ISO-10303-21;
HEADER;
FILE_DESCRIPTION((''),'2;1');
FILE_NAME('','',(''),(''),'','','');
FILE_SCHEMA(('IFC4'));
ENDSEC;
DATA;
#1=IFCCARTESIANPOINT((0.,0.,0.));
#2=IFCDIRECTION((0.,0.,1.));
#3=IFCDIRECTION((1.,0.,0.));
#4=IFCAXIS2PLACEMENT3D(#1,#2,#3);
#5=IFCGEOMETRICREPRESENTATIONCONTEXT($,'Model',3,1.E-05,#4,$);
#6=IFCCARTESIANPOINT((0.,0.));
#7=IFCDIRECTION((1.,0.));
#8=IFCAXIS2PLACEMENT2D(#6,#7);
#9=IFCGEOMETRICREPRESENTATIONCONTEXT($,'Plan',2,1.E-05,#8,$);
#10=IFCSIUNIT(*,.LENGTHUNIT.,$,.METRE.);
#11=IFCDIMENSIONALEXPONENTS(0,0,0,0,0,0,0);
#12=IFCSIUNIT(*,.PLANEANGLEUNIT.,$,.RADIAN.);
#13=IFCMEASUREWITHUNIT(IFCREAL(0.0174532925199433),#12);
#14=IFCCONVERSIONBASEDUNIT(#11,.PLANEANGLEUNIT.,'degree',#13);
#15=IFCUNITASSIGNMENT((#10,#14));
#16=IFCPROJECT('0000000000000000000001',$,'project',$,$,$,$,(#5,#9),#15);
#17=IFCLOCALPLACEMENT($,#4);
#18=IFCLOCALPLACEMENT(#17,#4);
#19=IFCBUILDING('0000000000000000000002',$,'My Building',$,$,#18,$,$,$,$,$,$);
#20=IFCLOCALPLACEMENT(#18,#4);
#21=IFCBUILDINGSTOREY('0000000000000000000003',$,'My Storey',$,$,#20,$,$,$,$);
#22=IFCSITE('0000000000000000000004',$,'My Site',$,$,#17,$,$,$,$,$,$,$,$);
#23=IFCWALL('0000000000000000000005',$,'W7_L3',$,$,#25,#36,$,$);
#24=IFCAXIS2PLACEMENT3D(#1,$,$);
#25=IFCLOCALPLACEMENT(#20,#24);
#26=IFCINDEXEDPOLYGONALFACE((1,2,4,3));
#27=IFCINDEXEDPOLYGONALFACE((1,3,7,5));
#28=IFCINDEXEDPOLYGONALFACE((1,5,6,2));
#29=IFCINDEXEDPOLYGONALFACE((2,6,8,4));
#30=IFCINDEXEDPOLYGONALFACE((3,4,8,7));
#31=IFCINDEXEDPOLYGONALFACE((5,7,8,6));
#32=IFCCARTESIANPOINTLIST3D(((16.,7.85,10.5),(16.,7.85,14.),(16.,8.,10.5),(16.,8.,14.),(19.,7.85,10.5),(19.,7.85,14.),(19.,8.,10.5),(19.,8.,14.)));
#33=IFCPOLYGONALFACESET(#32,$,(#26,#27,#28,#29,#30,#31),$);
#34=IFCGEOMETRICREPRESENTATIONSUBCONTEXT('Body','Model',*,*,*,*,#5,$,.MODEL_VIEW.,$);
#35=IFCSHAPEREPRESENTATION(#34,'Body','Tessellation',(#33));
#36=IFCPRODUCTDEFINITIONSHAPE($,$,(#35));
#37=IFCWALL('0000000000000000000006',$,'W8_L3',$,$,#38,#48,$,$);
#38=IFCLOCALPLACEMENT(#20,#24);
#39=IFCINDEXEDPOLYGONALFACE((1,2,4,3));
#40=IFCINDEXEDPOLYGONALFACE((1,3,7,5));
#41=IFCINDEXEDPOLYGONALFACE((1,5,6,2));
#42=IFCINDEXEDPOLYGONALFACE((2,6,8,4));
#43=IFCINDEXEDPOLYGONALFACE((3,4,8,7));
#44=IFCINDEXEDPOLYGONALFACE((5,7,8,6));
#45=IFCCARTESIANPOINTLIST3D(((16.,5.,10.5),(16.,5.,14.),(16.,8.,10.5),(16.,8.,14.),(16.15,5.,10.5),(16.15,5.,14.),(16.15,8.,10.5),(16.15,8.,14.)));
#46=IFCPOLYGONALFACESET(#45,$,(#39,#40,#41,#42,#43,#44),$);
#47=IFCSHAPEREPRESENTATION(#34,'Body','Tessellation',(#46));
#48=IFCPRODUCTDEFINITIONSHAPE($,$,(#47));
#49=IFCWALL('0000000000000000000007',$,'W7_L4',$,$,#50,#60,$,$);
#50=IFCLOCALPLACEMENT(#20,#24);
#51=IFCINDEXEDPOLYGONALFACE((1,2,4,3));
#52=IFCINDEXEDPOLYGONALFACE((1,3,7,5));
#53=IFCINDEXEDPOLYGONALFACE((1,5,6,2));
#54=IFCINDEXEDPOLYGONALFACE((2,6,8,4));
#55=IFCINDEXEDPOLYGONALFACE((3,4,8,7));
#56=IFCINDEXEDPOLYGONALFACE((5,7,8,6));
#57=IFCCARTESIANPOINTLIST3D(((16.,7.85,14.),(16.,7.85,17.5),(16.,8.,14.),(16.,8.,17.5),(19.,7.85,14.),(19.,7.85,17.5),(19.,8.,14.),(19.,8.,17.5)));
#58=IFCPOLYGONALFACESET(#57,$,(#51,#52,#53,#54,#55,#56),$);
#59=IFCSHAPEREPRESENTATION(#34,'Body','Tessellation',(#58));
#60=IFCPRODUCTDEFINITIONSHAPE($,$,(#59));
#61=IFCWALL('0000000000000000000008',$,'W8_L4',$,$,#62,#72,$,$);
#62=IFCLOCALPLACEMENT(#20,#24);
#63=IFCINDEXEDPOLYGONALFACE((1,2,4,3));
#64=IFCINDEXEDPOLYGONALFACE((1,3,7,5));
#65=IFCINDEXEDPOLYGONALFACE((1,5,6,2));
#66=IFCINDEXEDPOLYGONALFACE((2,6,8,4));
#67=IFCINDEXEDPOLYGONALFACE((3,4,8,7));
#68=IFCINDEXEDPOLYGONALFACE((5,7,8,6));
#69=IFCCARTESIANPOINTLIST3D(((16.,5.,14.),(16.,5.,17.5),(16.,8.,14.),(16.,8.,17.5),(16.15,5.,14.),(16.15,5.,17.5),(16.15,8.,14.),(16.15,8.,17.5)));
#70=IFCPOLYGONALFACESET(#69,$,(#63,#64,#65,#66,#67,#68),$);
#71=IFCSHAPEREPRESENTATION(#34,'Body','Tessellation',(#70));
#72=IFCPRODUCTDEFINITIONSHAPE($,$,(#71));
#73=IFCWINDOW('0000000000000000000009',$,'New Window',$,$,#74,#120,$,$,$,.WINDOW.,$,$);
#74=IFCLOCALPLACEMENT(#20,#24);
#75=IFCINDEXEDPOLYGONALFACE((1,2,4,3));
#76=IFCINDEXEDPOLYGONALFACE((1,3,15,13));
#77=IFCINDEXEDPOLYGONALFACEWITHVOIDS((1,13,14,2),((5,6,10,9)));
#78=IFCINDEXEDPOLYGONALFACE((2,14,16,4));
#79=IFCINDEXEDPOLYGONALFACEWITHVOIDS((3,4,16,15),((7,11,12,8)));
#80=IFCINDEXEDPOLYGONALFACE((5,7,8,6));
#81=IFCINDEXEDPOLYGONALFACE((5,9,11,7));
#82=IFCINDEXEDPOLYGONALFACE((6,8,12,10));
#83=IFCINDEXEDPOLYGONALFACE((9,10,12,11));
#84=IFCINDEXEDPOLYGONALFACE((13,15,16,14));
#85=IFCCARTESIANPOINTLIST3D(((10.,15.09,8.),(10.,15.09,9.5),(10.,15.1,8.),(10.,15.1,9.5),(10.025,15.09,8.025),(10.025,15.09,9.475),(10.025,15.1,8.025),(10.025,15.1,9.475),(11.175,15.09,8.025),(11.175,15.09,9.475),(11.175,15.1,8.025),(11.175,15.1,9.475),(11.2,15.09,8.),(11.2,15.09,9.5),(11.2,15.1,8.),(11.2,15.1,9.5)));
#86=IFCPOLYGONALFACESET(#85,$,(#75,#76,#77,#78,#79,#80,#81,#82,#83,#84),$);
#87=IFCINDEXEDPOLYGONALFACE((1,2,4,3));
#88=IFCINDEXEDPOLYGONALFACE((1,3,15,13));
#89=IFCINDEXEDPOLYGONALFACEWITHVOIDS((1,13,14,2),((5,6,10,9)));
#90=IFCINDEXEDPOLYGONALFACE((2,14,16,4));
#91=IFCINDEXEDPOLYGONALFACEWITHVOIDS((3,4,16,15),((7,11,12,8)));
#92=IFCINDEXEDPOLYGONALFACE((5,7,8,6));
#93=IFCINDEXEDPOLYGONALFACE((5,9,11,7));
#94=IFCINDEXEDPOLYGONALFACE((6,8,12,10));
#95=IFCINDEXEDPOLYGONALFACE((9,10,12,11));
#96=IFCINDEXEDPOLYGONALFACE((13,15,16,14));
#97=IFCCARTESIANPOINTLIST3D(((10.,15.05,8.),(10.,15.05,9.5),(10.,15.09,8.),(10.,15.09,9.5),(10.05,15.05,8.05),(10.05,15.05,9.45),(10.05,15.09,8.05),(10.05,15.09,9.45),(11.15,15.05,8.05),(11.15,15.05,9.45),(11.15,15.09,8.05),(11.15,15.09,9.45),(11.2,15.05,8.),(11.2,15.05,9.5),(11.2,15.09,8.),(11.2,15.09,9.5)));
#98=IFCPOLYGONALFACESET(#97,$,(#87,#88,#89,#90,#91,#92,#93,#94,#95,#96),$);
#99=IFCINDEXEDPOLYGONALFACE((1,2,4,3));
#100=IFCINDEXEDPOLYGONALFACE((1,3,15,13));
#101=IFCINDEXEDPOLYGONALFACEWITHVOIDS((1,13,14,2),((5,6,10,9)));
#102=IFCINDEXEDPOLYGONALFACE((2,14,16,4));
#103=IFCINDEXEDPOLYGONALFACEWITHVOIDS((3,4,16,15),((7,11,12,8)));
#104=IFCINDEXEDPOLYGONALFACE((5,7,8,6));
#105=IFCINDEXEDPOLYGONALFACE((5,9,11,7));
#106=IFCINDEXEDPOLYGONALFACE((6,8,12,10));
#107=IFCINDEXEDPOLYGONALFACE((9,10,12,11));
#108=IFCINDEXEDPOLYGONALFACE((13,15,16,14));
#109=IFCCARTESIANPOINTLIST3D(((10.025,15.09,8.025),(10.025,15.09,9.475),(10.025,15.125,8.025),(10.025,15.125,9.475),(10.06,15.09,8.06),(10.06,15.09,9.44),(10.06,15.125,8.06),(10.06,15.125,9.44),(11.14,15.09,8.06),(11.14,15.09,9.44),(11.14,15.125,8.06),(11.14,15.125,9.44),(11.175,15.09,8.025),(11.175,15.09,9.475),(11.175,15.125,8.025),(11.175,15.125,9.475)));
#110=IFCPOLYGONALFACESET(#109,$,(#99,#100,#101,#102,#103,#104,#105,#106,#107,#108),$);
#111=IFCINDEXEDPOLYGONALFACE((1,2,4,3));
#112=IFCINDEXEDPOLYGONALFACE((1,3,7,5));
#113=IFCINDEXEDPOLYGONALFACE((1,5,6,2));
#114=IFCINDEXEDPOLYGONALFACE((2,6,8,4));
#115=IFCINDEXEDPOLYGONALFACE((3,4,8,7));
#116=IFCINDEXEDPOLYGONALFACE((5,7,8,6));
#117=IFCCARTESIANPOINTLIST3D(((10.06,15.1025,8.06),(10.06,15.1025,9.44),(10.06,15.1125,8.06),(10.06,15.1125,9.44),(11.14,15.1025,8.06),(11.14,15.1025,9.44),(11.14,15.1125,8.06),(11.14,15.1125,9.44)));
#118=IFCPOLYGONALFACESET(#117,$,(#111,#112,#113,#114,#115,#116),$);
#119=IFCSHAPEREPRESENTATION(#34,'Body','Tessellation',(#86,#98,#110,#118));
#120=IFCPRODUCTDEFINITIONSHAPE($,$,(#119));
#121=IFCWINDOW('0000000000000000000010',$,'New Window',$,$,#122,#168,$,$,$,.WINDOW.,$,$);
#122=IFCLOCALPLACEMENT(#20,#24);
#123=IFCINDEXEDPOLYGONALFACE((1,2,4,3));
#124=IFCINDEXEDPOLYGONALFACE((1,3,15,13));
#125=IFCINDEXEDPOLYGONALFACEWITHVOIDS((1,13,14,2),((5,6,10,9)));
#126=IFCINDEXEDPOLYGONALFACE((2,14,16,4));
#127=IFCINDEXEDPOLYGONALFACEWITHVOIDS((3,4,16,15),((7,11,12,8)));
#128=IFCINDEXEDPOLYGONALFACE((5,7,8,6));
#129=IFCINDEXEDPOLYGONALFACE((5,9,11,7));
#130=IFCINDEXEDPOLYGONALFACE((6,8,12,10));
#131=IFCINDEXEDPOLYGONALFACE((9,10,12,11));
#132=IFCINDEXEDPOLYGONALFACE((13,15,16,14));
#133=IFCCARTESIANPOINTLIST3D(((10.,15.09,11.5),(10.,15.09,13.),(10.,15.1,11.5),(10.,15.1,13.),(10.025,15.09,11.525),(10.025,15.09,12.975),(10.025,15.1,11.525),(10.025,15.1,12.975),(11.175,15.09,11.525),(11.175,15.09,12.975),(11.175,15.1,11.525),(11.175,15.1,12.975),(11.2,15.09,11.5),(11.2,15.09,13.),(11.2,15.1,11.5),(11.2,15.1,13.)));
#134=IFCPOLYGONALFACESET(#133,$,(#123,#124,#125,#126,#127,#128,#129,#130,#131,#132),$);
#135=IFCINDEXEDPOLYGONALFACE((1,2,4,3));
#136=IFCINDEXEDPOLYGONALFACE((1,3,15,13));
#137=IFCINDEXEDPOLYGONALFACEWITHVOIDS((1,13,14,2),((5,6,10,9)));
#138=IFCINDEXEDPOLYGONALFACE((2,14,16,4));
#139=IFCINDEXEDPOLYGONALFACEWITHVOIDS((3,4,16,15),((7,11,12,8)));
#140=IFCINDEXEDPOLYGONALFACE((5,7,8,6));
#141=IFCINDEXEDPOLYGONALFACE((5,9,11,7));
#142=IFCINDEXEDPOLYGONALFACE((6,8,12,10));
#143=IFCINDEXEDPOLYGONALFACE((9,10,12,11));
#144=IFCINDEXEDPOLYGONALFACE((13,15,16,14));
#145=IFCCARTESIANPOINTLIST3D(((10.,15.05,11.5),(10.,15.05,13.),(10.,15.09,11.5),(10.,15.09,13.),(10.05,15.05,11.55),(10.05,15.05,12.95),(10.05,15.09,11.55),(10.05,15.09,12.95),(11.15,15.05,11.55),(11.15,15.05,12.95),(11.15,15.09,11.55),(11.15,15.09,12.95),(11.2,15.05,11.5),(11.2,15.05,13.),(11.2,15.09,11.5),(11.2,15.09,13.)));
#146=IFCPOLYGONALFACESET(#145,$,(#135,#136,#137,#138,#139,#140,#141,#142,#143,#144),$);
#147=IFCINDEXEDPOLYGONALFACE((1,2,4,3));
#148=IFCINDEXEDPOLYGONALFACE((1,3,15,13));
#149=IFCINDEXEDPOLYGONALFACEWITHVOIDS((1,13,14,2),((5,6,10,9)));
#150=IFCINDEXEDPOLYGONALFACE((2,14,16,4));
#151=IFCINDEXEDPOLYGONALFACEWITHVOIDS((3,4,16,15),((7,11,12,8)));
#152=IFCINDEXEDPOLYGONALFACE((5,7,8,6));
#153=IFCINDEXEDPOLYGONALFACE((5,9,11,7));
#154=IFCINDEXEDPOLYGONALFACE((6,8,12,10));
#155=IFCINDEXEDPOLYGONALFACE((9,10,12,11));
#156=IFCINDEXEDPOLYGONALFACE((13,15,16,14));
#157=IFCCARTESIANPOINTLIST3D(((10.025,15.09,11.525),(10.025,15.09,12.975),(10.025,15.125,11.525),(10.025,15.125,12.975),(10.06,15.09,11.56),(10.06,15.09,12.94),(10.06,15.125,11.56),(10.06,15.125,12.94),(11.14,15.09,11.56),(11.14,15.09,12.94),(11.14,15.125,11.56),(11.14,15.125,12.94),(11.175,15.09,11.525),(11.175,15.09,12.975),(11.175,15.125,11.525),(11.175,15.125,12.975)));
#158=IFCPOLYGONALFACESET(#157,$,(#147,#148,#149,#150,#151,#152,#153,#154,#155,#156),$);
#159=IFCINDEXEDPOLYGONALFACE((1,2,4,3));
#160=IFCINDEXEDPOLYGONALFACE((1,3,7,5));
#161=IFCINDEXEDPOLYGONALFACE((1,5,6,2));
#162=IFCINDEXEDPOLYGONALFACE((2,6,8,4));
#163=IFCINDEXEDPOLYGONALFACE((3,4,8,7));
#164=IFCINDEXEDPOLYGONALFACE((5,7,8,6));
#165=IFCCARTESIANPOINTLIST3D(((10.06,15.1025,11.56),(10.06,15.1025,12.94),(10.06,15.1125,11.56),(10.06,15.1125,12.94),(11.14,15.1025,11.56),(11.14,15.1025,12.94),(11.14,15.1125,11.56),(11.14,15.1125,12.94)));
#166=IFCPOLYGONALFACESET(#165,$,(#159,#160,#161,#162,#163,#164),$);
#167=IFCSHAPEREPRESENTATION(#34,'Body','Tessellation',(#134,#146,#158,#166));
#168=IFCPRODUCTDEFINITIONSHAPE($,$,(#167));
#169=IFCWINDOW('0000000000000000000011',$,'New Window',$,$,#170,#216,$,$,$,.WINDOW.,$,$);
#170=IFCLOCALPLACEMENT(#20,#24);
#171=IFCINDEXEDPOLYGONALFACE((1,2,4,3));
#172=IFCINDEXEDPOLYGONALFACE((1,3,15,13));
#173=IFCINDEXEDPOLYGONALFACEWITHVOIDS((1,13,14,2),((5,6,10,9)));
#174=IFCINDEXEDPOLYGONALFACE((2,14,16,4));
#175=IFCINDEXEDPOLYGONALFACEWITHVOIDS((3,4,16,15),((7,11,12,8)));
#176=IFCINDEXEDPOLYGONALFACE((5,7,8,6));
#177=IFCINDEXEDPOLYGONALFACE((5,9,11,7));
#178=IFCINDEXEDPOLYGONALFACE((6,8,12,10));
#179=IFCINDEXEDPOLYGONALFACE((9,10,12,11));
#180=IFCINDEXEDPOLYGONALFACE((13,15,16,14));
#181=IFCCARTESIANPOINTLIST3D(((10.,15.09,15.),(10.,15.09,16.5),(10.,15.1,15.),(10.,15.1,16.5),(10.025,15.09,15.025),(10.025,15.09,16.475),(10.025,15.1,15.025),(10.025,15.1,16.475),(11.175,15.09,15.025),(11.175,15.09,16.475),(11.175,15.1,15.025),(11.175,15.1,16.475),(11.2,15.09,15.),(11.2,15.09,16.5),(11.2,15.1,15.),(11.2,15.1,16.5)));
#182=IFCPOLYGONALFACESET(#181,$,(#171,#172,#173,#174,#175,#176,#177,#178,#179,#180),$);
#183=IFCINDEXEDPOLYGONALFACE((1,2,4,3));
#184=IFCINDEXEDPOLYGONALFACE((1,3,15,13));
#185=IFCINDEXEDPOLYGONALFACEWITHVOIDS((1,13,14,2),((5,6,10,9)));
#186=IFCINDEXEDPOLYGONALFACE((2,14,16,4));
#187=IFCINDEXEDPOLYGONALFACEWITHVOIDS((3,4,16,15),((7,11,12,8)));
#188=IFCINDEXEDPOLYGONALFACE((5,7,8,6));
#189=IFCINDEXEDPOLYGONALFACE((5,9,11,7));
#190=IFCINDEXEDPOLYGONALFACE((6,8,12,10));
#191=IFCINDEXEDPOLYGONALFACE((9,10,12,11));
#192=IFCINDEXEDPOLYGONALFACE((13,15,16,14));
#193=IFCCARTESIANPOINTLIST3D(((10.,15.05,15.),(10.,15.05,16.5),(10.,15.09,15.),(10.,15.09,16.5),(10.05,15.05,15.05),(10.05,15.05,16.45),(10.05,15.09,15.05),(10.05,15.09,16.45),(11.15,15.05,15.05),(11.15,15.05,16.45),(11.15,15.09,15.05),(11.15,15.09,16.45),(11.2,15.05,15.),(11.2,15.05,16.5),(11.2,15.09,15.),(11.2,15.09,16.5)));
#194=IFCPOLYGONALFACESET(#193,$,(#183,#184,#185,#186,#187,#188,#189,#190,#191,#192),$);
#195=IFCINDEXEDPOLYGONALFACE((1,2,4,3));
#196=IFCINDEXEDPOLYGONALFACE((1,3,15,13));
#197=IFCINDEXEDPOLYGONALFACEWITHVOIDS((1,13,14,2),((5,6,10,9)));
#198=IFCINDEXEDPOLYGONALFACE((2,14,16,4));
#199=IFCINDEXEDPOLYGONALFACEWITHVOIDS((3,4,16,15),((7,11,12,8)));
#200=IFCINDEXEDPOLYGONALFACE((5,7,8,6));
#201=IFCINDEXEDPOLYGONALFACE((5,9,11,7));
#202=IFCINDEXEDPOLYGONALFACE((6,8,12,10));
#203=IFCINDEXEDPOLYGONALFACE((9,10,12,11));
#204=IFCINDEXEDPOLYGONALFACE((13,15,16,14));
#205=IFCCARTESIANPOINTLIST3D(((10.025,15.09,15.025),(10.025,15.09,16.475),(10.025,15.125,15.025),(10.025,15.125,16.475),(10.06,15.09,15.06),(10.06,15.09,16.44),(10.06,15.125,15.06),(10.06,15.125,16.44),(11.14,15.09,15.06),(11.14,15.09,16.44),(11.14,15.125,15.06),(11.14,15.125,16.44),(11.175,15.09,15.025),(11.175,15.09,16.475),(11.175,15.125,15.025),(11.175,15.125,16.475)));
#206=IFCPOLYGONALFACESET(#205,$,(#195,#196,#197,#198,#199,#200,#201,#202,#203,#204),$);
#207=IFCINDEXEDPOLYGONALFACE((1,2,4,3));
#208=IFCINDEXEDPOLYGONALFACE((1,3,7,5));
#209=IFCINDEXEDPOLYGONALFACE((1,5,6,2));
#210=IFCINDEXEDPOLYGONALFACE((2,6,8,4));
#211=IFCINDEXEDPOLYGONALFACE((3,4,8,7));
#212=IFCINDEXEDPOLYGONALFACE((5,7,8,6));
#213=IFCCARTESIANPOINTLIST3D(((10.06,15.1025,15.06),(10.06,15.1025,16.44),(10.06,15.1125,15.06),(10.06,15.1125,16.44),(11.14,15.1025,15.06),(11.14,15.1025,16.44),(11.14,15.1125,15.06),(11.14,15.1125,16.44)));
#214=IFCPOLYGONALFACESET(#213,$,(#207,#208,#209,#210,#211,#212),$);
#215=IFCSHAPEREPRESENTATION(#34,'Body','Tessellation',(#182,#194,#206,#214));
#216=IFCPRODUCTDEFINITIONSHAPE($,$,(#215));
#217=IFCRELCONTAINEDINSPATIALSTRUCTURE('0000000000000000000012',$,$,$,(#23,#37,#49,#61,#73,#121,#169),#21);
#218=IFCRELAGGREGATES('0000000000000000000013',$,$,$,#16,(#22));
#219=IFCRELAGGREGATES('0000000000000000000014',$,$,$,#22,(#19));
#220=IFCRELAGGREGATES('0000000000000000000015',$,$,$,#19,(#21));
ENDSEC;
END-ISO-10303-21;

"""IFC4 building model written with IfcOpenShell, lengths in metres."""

from ifc_helpers import new_model, entity, si_unit, converted_unit, frame, origin_with_axes, origin_2d_with_axis, place, context, subcontext, project, spatial, line, indexed_curve, outline, extrude, element, save


model = new_model("IFC4")

# Units and contexts
model_context = context("Model", 3, precision=1e-05, world=origin_with_axes())
plan_context = context("Plan", 2, precision=1e-05, world=origin_2d_with_axis())
body_context = subcontext(model_context, "Body", "Model", "MODEL_VIEW")
ifc_project = project(units=[si_unit("LENGTHUNIT", "METRE"), converted_unit("PLANEANGLEUNIT", "degree", entity("IfcReal", 0.0174532925199433), si_unit("PLANEANGLEUNIT", "RADIAN"), dimensions=[0, 0, 0, 0, 0, 0, 0])], contexts=[model_context, plan_context])

# Site, building, storey
site_placement = place(None, origin_with_axes())
site = spatial("IfcSite", under=ifc_project, at=site_placement, Name="My Site")
building_placement = place(site_placement, origin_with_axes())
building = spatial("IfcBuilding", under=site, at=building_placement, Name="My Building")
storey_placement = place(building_placement, origin_with_axes())
storey = spatial("IfcBuildingStorey", under=building, at=storey_placement, Name="My Storey")

# Walls
for number, where, z_axis, x_axis, name in (
    (1, (19.0, 8.0, 10.5), (0.0, 0.0, 1.0), (-1.0, 0.0, 0.0), "W7_L3"),
    (2, (16.0, 8.0, 10.5), (0.0, 0.0, 1.0), (0.0, -1.0, 0.0), "W8_L3"),
):
    element("IfcWall", number, at=place(storey_placement, frame(where, z_axis=z_axis, x_axis=x_axis)), inside=storey, Name=name, context=body_context, shape_type="SweptSolid", body=[
        extrude(outline(indexed_curve([(0.0, 0.0), (0.0, 0.15), (3.0, 0.15), (3.0, 0.0), (0.0, 0.0)], self_intersect=False)), origin_with_axes(), (0.0, 0.0, 1.0), 3.5),
    ])
for number, where, z_axis, x_axis, name in (
    (3, (19.0, 8.0, 14.0), (0.0, 0.0, 1.0), (-1.0, 0.0, 0.0), "W7_L4"),
    (4, (16.0, 8.0, 14.0), (0.0, 0.0, 1.0), (0.0, -1.0, 0.0), "W8_L4"),
):
    element("IfcWall", number, at=place(storey_placement, frame(where, z_axis=z_axis, x_axis=x_axis)), inside=storey, Name=name, context=body_context, shape_type="SweptSolid", body=[
        extrude(outline(indexed_curve([(0.0, 0.0), (0.0, 0.15), (3.0, 0.15), (3.0, 0.0), (0.0, 0.0)], self_intersect=False)), origin_with_axes(), (0.0, 0.0, 1.0), 3.5),
    ])

# Windows
for number, where, z_axis, x_axis, name in (
    (5, (10.0, 15.0, 8.0), (0.0, 0.0, 1.0), (1.0, 0.0, 0.0), "New Window"),
    (6, (10.0, 15.0, 11.5), (0.0, 0.0, 1.0), (1.0, 0.0, 0.0), "New Window"),
    (7, (10.0, 15.0, 15.0), (0.0, 0.0, 1.0), (1.0, 0.0, 0.0), "New Window"),
):
    element("IfcWindow", number, at=place(storey_placement, frame(where, z_axis=z_axis, x_axis=x_axis)), inside=storey, Name=name, PredefinedType="WINDOW", context=body_context, shape_type="SweptSolid", body=[
        extrude(outline(indexed_curve([(0.0, 0.0), (1.2, 0.0), (1.2, 1.5), (0.0, 1.5)], segments=[line(1, 2, 3, 4, 1)]), holes=[indexed_curve([(0.025, 0.025), (1.175, 0.025), (1.175, 1.475), (0.025, 1.475)], segments=[line(1, 2, 3, 4, 1)])]), frame((0.0, 0.09, 0.0), z_axis=(0.0, -1.0, 0.0), x_axis=(1.0, 0.0, 0.0)), (0.0, 0.0, -1.0), 0.01),
        extrude(outline(indexed_curve([(0.0, 0.0), (1.2, 0.0), (1.2, 1.5), (0.0, 1.5)], segments=[line(1, 2, 3, 4, 1)]), holes=[indexed_curve([(0.05, 0.05), (1.15, 0.05), (1.15, 1.45), (0.05, 1.45)], segments=[line(1, 2, 3, 4, 1)])]), frame((0.0, 0.05, 0.0), z_axis=(0.0, -1.0, 0.0), x_axis=(1.0, 0.0, 0.0)), (0.0, 0.0, -1.0), 0.04),
        extrude(outline(indexed_curve([(0.0, 0.0), (1.15, 0.0), (1.15, 1.45), (0.0, 1.45)], segments=[line(1, 2, 3, 4, 1)]), holes=[indexed_curve([(0.035, 0.035), (1.115, 0.035), (1.115, 1.415), (0.035, 1.415)], segments=[line(1, 2, 3, 4, 1)])]), frame((0.025, 0.09, 0.025), z_axis=(0.0, -1.0, 0.0), x_axis=(1.0, 0.0, 0.0)), (0.0, 0.0, -1.0), 0.035),
        extrude(outline(indexed_curve([(0.035, 0.035), (1.115, 0.035), (1.115, 1.415), (0.035, 1.415)], segments=[line(1, 2, 3, 4, 1)])), frame((0.025, 0.1025, 0.025), z_axis=(0.0, -1.0, 0.0), x_axis=(1.0, 0.0, 0.0)), (0.0, 0.0, -1.0), 0.01),
    ])

save(model, "model.ifc")
